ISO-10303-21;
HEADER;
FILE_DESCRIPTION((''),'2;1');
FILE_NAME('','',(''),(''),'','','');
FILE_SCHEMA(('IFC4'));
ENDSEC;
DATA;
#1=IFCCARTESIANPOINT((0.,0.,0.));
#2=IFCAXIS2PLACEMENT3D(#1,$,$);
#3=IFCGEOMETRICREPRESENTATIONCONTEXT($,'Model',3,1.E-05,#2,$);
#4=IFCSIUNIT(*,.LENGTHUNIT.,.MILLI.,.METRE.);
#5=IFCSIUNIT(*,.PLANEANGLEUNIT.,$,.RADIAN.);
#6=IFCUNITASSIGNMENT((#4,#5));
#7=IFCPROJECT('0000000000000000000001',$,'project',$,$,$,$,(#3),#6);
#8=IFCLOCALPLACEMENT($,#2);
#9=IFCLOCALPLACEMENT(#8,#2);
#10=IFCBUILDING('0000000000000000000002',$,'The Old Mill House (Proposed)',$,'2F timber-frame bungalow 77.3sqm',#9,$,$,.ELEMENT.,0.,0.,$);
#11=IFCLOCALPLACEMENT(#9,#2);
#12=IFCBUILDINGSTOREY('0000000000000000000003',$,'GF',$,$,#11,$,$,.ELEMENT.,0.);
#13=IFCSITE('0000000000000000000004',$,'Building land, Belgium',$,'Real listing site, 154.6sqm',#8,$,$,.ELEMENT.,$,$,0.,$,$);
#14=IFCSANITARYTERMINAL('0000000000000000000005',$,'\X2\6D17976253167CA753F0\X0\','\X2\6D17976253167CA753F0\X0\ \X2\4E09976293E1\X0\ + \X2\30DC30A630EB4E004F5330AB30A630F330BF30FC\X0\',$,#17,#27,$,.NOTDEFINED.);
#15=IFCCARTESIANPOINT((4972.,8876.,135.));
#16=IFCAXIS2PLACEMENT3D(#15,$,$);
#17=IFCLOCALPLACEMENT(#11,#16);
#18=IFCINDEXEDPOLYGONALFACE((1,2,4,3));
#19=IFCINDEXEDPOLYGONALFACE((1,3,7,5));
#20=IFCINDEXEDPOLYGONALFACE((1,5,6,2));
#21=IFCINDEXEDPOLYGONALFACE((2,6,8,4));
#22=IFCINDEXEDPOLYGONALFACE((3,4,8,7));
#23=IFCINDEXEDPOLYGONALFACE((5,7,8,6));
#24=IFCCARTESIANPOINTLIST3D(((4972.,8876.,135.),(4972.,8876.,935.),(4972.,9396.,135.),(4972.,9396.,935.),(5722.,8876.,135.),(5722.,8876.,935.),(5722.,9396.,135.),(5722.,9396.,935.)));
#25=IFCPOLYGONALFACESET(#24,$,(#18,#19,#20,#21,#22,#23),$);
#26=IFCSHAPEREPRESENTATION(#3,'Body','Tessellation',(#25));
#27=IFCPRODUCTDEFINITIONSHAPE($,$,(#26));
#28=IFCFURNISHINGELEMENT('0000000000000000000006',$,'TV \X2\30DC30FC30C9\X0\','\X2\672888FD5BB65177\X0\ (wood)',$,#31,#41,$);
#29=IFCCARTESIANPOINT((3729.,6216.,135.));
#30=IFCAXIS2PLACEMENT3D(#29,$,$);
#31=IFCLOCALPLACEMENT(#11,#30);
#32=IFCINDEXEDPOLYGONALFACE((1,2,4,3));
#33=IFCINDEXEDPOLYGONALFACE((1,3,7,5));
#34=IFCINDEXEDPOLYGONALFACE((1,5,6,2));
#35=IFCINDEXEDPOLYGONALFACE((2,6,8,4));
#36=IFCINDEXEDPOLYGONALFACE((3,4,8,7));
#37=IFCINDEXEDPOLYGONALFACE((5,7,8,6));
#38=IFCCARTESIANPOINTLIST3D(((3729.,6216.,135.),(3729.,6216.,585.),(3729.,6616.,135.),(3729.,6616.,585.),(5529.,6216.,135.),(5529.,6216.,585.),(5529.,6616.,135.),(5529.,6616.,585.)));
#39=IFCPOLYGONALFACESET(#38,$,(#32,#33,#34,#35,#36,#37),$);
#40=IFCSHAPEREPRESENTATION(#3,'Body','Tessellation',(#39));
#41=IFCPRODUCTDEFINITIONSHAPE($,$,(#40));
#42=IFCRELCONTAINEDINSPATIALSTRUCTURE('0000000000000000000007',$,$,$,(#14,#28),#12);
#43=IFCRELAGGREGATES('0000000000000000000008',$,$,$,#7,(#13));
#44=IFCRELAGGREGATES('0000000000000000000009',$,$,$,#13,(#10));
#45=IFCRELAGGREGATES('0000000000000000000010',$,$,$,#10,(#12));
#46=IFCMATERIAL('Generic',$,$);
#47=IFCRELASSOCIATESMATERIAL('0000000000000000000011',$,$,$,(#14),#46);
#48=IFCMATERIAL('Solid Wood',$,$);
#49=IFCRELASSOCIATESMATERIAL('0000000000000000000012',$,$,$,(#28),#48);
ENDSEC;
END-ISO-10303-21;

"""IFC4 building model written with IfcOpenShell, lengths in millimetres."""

from ifc_helpers import new_model, si_unit, frame, frame_2d, origin, place, context, project, spatial, rectangle, extrude, material, element, save


model = new_model("IFC4")

# Units and contexts
model_context = context("Model", 3, precision=1e-05, world=origin())
ifc_project = project(units=[si_unit("LENGTHUNIT", "METRE", prefix="MILLI"), si_unit("PLANEANGLEUNIT", "RADIAN")], contexts=[model_context])

# Site, building, storey
site_placement = place(None, origin())
site = spatial("IfcSite", under=ifc_project, at=site_placement, Name="Building land, Belgium", ObjectType="Real listing site, 154.6sqm", CompositionType="ELEMENT", RefElevation=0.0)
building_placement = place(site_placement, origin())
building = spatial("IfcBuilding", under=site, at=building_placement, Name="The Old Mill House (Proposed)", ObjectType="2F timber-frame bungalow 77.3sqm", CompositionType="ELEMENT", ElevationOfRefHeight=0.0, ElevationOfTerrain=0.0)
storey_placement = place(building_placement, origin())
storey = spatial("IfcBuildingStorey", under=building, at=storey_placement, Name="GF", CompositionType="ELEMENT", Elevation=0.0)

# Shared definitions
ifc_material_1 = material(Name="Solid Wood")

# Shared definitions
ifc_material_2 = material(Name="Generic")

# Sanitary terminal
sanitary_terminal_1_placement = place(storey_placement, frame((4972.0, 8876.0, 135.0)))
element("IfcSanitaryTerminal", 1, at=sanitary_terminal_1_placement, inside=storey, material=ifc_material_2, Name="洗面化粧台", Description="洗面化粧台 三面鏡 + ボウル一体カウンター", PredefinedType="NOTDEFINED", context=model_context, shape_type="SweptSolid", body=[
    extrude(rectangle(XDim=750.0, YDim=520.0, at=frame_2d((375.0, 260.0))), frame((4972.0, 8876.0, 135.0)), (0.0, 0.0, 1.0), 800.0),
])

# Furnishing element
furnishing_placement = place(storey_placement, frame((3729.0, 6216.0, 135.0)))
element("IfcFurnishingElement", 2, at=furnishing_placement, inside=storey, material=ifc_material_1, Name="TV ボード", Description="木製家具 (wood)", context=model_context, shape_type="SweptSolid", body=[
    extrude(rectangle(XDim=1800.0, YDim=400.0, at=frame_2d((900.0, 200.0))), frame((3729.0, 6216.0, 135.0)), (0.0, 0.0, 1.0), 450.0),
])

save(model, "model.ifc")
